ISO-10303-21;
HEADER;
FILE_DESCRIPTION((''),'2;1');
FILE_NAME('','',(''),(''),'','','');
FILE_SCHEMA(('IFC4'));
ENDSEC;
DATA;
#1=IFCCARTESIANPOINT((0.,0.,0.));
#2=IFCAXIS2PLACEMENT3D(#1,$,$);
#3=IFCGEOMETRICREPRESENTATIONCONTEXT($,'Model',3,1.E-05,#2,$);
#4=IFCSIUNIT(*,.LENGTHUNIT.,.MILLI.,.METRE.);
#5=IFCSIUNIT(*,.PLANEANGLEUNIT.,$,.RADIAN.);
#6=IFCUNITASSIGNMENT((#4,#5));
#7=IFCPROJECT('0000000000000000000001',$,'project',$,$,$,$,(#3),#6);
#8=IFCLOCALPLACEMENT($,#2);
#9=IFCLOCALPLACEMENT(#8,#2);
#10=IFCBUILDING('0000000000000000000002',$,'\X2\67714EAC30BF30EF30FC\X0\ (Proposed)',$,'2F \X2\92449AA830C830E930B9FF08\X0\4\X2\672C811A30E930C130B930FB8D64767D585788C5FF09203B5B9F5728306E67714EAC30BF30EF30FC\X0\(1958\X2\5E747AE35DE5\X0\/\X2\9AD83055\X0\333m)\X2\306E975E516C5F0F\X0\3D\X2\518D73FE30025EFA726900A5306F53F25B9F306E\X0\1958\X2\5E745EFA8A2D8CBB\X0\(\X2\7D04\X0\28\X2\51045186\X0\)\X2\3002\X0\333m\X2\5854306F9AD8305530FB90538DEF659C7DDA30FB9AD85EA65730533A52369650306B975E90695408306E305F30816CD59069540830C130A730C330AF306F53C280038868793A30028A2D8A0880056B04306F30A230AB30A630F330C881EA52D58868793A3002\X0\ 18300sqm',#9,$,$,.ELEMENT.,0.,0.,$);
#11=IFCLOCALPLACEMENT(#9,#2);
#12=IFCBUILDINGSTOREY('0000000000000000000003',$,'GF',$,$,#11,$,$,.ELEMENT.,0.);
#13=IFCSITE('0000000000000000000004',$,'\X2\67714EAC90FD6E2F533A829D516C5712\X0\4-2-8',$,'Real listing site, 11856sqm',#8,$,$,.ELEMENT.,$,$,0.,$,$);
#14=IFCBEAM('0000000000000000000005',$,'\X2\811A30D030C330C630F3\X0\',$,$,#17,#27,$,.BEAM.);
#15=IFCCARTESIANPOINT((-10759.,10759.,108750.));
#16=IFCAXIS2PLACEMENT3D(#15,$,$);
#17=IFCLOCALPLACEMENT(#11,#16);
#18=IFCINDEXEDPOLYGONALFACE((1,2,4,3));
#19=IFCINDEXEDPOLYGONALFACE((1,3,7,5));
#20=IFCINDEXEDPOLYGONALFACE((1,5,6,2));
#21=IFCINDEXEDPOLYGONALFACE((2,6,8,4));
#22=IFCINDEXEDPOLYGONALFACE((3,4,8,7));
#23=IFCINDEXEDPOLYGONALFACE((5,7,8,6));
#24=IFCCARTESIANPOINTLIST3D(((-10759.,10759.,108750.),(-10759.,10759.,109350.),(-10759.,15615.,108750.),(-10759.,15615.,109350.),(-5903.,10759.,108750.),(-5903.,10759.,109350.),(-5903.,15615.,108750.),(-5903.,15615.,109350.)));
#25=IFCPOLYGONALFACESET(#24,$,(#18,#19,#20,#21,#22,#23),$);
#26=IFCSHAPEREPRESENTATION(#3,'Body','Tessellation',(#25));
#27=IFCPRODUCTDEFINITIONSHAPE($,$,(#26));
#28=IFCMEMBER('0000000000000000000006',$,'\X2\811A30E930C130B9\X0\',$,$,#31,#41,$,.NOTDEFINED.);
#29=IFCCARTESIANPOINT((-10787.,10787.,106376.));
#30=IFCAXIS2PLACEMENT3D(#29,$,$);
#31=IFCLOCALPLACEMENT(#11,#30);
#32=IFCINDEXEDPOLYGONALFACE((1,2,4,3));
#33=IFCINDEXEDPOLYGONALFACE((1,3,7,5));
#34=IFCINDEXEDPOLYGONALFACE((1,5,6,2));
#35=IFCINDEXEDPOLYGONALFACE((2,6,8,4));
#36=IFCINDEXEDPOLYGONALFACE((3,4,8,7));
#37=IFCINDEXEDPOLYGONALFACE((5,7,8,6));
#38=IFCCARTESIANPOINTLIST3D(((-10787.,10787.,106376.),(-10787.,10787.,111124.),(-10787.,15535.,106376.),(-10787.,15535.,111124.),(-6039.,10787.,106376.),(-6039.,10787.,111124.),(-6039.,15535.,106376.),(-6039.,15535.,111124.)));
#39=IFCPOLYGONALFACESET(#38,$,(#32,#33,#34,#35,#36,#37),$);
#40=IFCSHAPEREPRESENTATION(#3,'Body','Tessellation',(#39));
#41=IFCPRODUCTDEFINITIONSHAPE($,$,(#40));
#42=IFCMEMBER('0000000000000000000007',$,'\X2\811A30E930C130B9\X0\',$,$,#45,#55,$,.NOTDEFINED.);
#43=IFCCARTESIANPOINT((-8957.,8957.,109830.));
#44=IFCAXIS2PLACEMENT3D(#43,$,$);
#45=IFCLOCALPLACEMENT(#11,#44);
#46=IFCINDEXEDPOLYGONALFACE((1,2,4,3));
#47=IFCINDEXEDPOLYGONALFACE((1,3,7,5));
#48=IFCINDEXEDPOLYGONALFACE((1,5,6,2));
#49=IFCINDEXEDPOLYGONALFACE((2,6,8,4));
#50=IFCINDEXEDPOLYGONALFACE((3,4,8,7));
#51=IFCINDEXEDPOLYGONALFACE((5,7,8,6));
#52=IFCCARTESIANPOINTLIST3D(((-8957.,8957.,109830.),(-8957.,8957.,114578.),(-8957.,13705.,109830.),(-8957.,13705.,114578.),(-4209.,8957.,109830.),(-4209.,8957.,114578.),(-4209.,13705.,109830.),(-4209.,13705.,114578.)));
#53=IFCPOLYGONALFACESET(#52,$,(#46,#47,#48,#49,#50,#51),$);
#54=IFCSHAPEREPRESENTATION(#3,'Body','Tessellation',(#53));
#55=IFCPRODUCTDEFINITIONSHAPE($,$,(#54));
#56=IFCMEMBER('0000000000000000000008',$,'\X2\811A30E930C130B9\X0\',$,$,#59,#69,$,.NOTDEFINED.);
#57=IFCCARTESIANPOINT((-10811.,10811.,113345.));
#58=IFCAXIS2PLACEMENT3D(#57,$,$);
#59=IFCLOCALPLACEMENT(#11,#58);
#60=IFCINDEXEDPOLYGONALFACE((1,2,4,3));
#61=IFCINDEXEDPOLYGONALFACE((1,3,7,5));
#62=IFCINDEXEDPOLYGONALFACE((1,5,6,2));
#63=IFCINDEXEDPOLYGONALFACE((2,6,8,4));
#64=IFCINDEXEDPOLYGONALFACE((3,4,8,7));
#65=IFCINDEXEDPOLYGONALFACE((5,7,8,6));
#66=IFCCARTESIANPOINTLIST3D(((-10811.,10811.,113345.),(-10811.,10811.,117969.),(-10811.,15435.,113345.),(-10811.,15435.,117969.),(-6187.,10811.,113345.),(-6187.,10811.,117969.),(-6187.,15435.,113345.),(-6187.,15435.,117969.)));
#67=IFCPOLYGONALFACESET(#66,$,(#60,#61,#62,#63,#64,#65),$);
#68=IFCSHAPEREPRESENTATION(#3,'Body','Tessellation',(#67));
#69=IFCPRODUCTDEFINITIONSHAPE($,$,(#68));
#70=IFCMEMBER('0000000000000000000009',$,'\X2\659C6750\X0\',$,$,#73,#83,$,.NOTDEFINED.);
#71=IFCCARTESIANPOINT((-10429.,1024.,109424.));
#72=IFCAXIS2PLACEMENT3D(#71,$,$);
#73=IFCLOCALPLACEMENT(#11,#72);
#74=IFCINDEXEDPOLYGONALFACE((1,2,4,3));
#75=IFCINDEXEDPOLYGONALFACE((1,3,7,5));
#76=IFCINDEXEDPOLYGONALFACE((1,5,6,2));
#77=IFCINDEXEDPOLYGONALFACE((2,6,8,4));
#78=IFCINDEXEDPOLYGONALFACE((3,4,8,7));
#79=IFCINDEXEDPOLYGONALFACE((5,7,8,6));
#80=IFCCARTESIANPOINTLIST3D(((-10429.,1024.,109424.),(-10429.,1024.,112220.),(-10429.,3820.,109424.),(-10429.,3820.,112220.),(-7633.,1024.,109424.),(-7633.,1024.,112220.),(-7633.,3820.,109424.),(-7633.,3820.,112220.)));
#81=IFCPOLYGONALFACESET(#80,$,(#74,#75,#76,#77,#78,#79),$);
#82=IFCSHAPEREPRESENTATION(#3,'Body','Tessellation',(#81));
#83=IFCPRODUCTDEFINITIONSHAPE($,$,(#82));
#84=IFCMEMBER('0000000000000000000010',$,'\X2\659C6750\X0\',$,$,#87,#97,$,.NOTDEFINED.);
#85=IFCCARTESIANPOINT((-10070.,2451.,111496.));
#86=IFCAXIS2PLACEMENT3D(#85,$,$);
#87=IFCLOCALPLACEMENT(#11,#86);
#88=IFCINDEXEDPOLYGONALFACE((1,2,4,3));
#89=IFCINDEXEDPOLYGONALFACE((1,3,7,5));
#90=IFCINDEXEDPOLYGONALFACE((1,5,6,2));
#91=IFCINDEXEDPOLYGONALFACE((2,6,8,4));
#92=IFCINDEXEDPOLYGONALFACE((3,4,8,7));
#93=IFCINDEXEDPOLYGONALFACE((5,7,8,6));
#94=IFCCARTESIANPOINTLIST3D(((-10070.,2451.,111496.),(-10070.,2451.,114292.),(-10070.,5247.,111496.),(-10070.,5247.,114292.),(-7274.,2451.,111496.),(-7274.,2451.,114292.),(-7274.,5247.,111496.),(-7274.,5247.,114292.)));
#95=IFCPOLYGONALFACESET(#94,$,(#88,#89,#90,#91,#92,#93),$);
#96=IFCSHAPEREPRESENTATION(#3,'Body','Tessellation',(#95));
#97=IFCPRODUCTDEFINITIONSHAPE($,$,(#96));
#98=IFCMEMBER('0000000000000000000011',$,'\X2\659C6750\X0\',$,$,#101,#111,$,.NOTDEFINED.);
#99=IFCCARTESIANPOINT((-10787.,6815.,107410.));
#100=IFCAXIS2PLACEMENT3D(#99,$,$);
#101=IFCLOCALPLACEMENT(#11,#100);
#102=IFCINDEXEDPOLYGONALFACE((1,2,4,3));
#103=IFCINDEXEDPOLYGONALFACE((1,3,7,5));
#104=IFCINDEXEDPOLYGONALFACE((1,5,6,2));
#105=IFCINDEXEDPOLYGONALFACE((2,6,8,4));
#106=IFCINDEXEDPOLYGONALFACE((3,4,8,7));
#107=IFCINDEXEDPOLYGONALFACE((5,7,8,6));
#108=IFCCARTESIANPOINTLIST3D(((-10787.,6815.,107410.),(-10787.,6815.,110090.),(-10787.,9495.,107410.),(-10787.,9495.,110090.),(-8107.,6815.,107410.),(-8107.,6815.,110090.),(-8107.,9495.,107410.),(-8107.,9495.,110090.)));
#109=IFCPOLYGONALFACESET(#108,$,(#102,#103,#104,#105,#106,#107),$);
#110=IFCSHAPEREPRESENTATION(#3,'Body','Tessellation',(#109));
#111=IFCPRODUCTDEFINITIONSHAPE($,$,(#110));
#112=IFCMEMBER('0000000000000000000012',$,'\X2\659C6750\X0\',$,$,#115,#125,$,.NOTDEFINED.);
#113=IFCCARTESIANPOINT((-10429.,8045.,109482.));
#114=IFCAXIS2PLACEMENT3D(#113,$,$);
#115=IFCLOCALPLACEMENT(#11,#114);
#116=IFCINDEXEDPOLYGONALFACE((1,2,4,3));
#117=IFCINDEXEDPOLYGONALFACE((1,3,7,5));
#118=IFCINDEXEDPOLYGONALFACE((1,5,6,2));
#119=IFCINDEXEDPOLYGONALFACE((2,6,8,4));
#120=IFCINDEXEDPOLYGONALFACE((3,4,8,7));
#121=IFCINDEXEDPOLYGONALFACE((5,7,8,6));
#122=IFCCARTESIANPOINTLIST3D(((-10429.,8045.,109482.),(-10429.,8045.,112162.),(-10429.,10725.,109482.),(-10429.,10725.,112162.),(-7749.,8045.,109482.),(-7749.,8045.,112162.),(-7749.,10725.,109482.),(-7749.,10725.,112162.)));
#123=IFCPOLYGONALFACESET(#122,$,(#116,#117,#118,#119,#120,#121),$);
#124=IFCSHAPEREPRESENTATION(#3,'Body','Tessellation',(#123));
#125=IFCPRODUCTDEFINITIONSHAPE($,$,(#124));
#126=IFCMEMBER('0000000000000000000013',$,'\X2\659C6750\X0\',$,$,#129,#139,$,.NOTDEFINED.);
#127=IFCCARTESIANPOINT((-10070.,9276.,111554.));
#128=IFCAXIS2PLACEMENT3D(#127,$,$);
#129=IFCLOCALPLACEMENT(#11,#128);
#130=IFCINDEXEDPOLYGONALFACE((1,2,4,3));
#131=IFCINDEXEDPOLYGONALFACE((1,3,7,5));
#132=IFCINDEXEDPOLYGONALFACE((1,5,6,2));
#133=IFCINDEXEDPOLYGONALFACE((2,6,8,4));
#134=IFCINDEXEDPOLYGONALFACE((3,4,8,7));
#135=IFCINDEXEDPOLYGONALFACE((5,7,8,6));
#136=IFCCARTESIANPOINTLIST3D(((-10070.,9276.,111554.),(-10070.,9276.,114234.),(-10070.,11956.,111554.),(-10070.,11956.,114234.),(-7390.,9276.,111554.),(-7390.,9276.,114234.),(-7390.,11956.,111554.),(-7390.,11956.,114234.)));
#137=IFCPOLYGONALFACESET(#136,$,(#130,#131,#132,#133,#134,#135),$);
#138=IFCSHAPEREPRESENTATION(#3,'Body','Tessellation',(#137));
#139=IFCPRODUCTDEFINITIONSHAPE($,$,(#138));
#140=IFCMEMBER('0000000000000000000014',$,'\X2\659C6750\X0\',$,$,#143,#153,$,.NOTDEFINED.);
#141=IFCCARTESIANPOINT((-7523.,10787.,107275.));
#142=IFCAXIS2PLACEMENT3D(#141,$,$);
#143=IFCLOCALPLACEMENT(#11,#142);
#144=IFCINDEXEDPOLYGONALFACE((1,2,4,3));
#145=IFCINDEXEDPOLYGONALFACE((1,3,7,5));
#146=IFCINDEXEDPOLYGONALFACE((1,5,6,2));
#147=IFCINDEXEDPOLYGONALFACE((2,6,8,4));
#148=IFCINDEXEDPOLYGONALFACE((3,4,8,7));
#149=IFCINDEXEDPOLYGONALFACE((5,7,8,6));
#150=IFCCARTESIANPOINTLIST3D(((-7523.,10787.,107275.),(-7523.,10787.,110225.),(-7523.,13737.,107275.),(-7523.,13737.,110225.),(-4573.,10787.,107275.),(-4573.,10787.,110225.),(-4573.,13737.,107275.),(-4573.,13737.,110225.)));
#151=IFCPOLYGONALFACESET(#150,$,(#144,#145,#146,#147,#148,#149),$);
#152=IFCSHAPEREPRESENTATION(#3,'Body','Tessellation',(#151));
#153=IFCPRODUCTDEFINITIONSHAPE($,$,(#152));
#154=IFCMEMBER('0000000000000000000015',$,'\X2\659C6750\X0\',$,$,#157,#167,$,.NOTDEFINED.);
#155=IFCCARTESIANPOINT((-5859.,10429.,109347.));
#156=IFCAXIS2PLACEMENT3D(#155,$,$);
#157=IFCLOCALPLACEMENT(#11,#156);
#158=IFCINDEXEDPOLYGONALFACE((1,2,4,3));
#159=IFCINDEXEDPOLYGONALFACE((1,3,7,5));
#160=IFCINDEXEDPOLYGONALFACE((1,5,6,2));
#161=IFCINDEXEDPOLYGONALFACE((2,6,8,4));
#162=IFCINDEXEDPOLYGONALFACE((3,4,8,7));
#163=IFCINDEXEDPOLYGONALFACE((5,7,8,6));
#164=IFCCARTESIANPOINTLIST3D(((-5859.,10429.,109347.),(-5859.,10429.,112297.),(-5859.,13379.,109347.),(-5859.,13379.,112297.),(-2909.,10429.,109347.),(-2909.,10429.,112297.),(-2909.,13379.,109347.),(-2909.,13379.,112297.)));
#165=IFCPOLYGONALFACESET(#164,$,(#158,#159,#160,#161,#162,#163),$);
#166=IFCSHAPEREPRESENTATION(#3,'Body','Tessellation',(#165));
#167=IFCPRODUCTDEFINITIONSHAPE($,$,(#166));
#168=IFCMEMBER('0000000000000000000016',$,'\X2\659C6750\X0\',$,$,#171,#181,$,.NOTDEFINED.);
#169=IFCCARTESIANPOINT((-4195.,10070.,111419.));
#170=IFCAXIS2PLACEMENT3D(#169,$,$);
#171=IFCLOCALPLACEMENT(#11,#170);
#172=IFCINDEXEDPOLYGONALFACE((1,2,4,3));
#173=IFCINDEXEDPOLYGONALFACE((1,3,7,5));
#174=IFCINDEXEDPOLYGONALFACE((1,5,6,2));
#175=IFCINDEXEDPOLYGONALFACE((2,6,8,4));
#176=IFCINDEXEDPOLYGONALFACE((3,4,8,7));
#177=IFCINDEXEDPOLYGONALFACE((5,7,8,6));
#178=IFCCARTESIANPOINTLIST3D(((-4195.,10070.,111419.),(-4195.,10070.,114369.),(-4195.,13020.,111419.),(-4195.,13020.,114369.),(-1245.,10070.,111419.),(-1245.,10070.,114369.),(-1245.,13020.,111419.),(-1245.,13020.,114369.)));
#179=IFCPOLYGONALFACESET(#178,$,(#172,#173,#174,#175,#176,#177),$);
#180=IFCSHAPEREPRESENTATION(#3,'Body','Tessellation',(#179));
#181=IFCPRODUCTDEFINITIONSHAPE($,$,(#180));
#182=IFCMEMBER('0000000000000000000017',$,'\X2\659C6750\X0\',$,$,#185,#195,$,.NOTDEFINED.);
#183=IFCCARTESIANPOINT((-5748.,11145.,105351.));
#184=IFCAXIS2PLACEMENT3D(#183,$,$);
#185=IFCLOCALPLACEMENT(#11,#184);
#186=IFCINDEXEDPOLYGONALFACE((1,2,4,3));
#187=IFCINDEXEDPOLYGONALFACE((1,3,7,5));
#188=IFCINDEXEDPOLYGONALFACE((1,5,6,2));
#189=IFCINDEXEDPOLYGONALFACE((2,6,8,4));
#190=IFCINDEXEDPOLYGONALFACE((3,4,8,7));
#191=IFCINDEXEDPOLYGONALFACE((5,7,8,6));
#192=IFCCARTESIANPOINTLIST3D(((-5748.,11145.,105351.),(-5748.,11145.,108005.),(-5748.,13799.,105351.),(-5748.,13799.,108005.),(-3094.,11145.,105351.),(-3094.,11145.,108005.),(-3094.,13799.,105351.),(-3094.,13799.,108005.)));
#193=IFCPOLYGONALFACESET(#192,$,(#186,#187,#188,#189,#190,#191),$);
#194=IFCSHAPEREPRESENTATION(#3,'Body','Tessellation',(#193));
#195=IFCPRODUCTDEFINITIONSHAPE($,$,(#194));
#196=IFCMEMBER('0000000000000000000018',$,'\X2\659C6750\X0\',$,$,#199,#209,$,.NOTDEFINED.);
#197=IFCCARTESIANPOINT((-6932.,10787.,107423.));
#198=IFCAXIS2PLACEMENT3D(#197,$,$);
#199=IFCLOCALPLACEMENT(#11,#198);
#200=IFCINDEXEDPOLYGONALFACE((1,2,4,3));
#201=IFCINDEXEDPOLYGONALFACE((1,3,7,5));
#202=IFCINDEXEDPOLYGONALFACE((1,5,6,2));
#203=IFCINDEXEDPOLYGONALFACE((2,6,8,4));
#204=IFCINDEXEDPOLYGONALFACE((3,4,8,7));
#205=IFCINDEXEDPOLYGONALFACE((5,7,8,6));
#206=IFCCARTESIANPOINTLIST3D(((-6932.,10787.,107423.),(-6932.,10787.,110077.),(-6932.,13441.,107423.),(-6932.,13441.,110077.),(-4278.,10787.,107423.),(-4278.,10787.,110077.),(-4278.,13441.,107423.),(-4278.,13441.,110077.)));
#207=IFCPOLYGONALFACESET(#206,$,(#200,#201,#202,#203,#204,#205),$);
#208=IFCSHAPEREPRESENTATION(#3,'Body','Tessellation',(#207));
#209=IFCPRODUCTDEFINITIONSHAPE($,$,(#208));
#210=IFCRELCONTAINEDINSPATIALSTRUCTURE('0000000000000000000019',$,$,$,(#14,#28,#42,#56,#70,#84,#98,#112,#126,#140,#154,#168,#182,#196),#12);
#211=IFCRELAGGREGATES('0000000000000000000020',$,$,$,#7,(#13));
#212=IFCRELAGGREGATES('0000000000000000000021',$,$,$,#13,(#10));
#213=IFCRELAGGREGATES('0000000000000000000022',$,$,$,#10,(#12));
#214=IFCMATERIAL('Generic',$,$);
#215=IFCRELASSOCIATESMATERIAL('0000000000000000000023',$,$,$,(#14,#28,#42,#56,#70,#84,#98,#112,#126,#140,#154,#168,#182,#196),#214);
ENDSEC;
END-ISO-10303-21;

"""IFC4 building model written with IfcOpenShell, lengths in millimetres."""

from ifc_helpers import new_model, si_unit, frame, frame_2d, origin, place, context, project, spatial, rectangle, extrude, material, element, save


model = new_model("IFC4")

# Units and contexts
model_context = context("Model", 3, precision=1e-05, world=origin())
ifc_project = project(units=[si_unit("LENGTHUNIT", "METRE", prefix="MILLI"), si_unit("PLANEANGLEUNIT", "RADIAN")], contexts=[model_context])

# Site, building, storey
site_placement = place(None, origin())
site = spatial("IfcSite", under=ifc_project, at=site_placement, Name="東京都港区芝公園4-2-8", ObjectType="Real listing site, 11856sqm", CompositionType="ELEMENT", RefElevation=0.0)
building_placement = place(site_placement, origin())
building = spatial("IfcBuilding", under=site, at=building_placement, Name="東京タワー (Proposed)", ObjectType="2F 鉄骨トラス（4本脚ラチス・赤白塗装）※実在の東京タワー(1958年竣工/高さ333m)の非公式3D再現。建物¥は史実の1958年建設費(約28億円)。333m塔は高さ・道路斜線・高度地区制限に非適合のため法適合チェックは参考表示。設計者欄はアカウント自動表示。 18300sqm", CompositionType="ELEMENT", ElevationOfRefHeight=0.0, ElevationOfTerrain=0.0)
storey_placement = place(building_placement, origin())
storey = spatial("IfcBuildingStorey", under=building, at=storey_placement, Name="GF", CompositionType="ELEMENT", Elevation=0.0)

# Beam
ifc_material = material(Name="Generic")
beam_placement = place(storey_placement, frame((-10759.0, 10759.0, 108750.0)))
element("IfcBeam", 1, at=beam_placement, inside=storey, material=ifc_material, Name="脚バッテン", PredefinedType="BEAM", context=model_context, shape_type="SweptSolid", body=[
    extrude(rectangle(XDim=4856.0, YDim=4856.0, at=frame_2d((2428.0, 2428.0))), frame((-10759.0, 10759.0, 108750.0)), (0.0, 0.0, 1.0), 600.0),
])

# Members
member_1_placement = place(storey_placement, frame((-10787.0, 10787.0, 106376.0)))
element("IfcMember", 2, at=member_1_placement, inside=storey, material=ifc_material, Name="脚ラチス", PredefinedType="NOTDEFINED", context=model_context, shape_type="SweptSolid", body=[
    extrude(rectangle(XDim=4748.0, YDim=4748.0, at=frame_2d((2374.0, 2374.0))), frame((-10787.0, 10787.0, 106376.0)), (0.0, 0.0, 1.0), 4748.0),
])
member_2_placement = place(storey_placement, frame((-8957.0, 8957.0, 109830.0)))
element("IfcMember", 3, at=member_2_placement, inside=storey, material=ifc_material, Name="脚ラチス", PredefinedType="NOTDEFINED", context=model_context, shape_type="SweptSolid", body=[
    extrude(rectangle(XDim=4748.0, YDim=4748.0, at=frame_2d((2374.0, 2374.0))), frame((-8957.0, 8957.0, 109830.0)), (0.0, 0.0, 1.0), 4748.0),
])
member_3_placement = place(storey_placement, frame((-10811.0, 10811.0, 113345.0)))
element("IfcMember", 4, at=member_3_placement, inside=storey, material=ifc_material, Name="脚ラチス", PredefinedType="NOTDEFINED", context=model_context, shape_type="SweptSolid", body=[
    extrude(rectangle(XDim=4624.0, YDim=4624.0, at=frame_2d((2312.0, 2312.0))), frame((-10811.0, 10811.0, 113345.0)), (0.0, 0.0, 1.0), 4624.0),
])
member_4_placement = place(storey_placement, frame((-10429.0, 1024.0, 109424.0)))
element("IfcMember", 5, at=member_4_placement, inside=storey, material=ifc_material, Name="斜材", PredefinedType="NOTDEFINED", context=model_context, shape_type="SweptSolid", body=[
    extrude(rectangle(XDim=2796.0, YDim=2796.0, at=frame_2d((1398.0, 1398.0))), frame((-10429.0, 1024.0, 109424.0)), (0.0, 0.0, 1.0), 2796.0),
])
member_5_placement = place(storey_placement, frame((-10070.0, 2451.0, 111496.0)))
element("IfcMember", 6, at=member_5_placement, inside=storey, material=ifc_material, Name="斜材", PredefinedType="NOTDEFINED", context=model_context, shape_type="SweptSolid", body=[
    extrude(rectangle(XDim=2796.0, YDim=2796.0, at=frame_2d((1398.0, 1398.0))), frame((-10070.0, 2451.0, 111496.0)), (0.0, 0.0, 1.0), 2796.0),
])
member_6_placement = place(storey_placement, frame((-10787.0, 6815.0, 107410.0)))
element("IfcMember", 7, at=member_6_placement, inside=storey, material=ifc_material, Name="斜材", PredefinedType="NOTDEFINED", context=model_context, shape_type="SweptSolid", body=[
    extrude(rectangle(XDim=2680.0, YDim=2680.0, at=frame_2d((1340.0, 1340.0))), frame((-10787.0, 6815.0, 107410.0)), (0.0, 0.0, 1.0), 2680.0),
])
member_7_placement = place(storey_placement, frame((-10429.0, 8045.0, 109482.0)))
element("IfcMember", 8, at=member_7_placement, inside=storey, material=ifc_material, Name="斜材", PredefinedType="NOTDEFINED", context=model_context, shape_type="SweptSolid", body=[
    extrude(rectangle(XDim=2680.0, YDim=2680.0, at=frame_2d((1340.0, 1340.0))), frame((-10429.0, 8045.0, 109482.0)), (0.0, 0.0, 1.0), 2680.0),
])
member_8_placement = place(storey_placement, frame((-10070.0, 9276.0, 111554.0)))
element("IfcMember", 9, at=member_8_placement, inside=storey, material=ifc_material, Name="斜材", PredefinedType="NOTDEFINED", context=model_context, shape_type="SweptSolid", body=[
    extrude(rectangle(XDim=2680.0, YDim=2680.0, at=frame_2d((1340.0, 1340.0))), frame((-10070.0, 9276.0, 111554.0)), (0.0, 0.0, 1.0), 2680.0),
])
member_9_placement = place(storey_placement, frame((-7523.0, 10787.0, 107275.0)))
element("IfcMember", 10, at=member_9_placement, inside=storey, material=ifc_material, Name="斜材", PredefinedType="NOTDEFINED", context=model_context, shape_type="SweptSolid", body=[
    extrude(rectangle(XDim=2950.0, YDim=2950.0, at=frame_2d((1475.0, 1475.0))), frame((-7523.0, 10787.0, 107275.0)), (0.0, 0.0, 1.0), 2950.0),
])
member_10_placement = place(storey_placement, frame((-5859.0, 10429.0, 109347.0)))
element("IfcMember", 11, at=member_10_placement, inside=storey, material=ifc_material, Name="斜材", PredefinedType="NOTDEFINED", context=model_context, shape_type="SweptSolid", body=[
    extrude(rectangle(XDim=2950.0, YDim=2950.0, at=frame_2d((1475.0, 1475.0))), frame((-5859.0, 10429.0, 109347.0)), (0.0, 0.0, 1.0), 2950.0),
])
member_11_placement = place(storey_placement, frame((-4195.0, 10070.0, 111419.0)))
element("IfcMember", 12, at=member_11_placement, inside=storey, material=ifc_material, Name="斜材", PredefinedType="NOTDEFINED", context=model_context, shape_type="SweptSolid", body=[
    extrude(rectangle(XDim=2950.0, YDim=2950.0, at=frame_2d((1475.0, 1475.0))), frame((-4195.0, 10070.0, 111419.0)), (0.0, 0.0, 1.0), 2950.0),
])
member_12_placement = place(storey_placement, frame((-5748.0, 11145.0, 105351.0)))
element("IfcMember", 13, at=member_12_placement, inside=storey, material=ifc_material, Name="斜材", PredefinedType="NOTDEFINED", context=model_context, shape_type="SweptSolid", body=[
    extrude(rectangle(XDim=2654.0, YDim=2654.0, at=frame_2d((1327.0, 1327.0))), frame((-5748.0, 11145.0, 105351.0)), (0.0, 0.0, 1.0), 2654.0),
])
member_13_placement = place(storey_placement, frame((-6932.0, 10787.0, 107423.0)))
element("IfcMember", 14, at=member_13_placement, inside=storey, material=ifc_material, Name="斜材", PredefinedType="NOTDEFINED", context=model_context, shape_type="SweptSolid", body=[
    extrude(rectangle(XDim=2654.0, YDim=2654.0, at=frame_2d((1327.0, 1327.0))), frame((-6932.0, 10787.0, 107423.0)), (0.0, 0.0, 1.0), 2654.0),
])

save(model, "model.ifc")
